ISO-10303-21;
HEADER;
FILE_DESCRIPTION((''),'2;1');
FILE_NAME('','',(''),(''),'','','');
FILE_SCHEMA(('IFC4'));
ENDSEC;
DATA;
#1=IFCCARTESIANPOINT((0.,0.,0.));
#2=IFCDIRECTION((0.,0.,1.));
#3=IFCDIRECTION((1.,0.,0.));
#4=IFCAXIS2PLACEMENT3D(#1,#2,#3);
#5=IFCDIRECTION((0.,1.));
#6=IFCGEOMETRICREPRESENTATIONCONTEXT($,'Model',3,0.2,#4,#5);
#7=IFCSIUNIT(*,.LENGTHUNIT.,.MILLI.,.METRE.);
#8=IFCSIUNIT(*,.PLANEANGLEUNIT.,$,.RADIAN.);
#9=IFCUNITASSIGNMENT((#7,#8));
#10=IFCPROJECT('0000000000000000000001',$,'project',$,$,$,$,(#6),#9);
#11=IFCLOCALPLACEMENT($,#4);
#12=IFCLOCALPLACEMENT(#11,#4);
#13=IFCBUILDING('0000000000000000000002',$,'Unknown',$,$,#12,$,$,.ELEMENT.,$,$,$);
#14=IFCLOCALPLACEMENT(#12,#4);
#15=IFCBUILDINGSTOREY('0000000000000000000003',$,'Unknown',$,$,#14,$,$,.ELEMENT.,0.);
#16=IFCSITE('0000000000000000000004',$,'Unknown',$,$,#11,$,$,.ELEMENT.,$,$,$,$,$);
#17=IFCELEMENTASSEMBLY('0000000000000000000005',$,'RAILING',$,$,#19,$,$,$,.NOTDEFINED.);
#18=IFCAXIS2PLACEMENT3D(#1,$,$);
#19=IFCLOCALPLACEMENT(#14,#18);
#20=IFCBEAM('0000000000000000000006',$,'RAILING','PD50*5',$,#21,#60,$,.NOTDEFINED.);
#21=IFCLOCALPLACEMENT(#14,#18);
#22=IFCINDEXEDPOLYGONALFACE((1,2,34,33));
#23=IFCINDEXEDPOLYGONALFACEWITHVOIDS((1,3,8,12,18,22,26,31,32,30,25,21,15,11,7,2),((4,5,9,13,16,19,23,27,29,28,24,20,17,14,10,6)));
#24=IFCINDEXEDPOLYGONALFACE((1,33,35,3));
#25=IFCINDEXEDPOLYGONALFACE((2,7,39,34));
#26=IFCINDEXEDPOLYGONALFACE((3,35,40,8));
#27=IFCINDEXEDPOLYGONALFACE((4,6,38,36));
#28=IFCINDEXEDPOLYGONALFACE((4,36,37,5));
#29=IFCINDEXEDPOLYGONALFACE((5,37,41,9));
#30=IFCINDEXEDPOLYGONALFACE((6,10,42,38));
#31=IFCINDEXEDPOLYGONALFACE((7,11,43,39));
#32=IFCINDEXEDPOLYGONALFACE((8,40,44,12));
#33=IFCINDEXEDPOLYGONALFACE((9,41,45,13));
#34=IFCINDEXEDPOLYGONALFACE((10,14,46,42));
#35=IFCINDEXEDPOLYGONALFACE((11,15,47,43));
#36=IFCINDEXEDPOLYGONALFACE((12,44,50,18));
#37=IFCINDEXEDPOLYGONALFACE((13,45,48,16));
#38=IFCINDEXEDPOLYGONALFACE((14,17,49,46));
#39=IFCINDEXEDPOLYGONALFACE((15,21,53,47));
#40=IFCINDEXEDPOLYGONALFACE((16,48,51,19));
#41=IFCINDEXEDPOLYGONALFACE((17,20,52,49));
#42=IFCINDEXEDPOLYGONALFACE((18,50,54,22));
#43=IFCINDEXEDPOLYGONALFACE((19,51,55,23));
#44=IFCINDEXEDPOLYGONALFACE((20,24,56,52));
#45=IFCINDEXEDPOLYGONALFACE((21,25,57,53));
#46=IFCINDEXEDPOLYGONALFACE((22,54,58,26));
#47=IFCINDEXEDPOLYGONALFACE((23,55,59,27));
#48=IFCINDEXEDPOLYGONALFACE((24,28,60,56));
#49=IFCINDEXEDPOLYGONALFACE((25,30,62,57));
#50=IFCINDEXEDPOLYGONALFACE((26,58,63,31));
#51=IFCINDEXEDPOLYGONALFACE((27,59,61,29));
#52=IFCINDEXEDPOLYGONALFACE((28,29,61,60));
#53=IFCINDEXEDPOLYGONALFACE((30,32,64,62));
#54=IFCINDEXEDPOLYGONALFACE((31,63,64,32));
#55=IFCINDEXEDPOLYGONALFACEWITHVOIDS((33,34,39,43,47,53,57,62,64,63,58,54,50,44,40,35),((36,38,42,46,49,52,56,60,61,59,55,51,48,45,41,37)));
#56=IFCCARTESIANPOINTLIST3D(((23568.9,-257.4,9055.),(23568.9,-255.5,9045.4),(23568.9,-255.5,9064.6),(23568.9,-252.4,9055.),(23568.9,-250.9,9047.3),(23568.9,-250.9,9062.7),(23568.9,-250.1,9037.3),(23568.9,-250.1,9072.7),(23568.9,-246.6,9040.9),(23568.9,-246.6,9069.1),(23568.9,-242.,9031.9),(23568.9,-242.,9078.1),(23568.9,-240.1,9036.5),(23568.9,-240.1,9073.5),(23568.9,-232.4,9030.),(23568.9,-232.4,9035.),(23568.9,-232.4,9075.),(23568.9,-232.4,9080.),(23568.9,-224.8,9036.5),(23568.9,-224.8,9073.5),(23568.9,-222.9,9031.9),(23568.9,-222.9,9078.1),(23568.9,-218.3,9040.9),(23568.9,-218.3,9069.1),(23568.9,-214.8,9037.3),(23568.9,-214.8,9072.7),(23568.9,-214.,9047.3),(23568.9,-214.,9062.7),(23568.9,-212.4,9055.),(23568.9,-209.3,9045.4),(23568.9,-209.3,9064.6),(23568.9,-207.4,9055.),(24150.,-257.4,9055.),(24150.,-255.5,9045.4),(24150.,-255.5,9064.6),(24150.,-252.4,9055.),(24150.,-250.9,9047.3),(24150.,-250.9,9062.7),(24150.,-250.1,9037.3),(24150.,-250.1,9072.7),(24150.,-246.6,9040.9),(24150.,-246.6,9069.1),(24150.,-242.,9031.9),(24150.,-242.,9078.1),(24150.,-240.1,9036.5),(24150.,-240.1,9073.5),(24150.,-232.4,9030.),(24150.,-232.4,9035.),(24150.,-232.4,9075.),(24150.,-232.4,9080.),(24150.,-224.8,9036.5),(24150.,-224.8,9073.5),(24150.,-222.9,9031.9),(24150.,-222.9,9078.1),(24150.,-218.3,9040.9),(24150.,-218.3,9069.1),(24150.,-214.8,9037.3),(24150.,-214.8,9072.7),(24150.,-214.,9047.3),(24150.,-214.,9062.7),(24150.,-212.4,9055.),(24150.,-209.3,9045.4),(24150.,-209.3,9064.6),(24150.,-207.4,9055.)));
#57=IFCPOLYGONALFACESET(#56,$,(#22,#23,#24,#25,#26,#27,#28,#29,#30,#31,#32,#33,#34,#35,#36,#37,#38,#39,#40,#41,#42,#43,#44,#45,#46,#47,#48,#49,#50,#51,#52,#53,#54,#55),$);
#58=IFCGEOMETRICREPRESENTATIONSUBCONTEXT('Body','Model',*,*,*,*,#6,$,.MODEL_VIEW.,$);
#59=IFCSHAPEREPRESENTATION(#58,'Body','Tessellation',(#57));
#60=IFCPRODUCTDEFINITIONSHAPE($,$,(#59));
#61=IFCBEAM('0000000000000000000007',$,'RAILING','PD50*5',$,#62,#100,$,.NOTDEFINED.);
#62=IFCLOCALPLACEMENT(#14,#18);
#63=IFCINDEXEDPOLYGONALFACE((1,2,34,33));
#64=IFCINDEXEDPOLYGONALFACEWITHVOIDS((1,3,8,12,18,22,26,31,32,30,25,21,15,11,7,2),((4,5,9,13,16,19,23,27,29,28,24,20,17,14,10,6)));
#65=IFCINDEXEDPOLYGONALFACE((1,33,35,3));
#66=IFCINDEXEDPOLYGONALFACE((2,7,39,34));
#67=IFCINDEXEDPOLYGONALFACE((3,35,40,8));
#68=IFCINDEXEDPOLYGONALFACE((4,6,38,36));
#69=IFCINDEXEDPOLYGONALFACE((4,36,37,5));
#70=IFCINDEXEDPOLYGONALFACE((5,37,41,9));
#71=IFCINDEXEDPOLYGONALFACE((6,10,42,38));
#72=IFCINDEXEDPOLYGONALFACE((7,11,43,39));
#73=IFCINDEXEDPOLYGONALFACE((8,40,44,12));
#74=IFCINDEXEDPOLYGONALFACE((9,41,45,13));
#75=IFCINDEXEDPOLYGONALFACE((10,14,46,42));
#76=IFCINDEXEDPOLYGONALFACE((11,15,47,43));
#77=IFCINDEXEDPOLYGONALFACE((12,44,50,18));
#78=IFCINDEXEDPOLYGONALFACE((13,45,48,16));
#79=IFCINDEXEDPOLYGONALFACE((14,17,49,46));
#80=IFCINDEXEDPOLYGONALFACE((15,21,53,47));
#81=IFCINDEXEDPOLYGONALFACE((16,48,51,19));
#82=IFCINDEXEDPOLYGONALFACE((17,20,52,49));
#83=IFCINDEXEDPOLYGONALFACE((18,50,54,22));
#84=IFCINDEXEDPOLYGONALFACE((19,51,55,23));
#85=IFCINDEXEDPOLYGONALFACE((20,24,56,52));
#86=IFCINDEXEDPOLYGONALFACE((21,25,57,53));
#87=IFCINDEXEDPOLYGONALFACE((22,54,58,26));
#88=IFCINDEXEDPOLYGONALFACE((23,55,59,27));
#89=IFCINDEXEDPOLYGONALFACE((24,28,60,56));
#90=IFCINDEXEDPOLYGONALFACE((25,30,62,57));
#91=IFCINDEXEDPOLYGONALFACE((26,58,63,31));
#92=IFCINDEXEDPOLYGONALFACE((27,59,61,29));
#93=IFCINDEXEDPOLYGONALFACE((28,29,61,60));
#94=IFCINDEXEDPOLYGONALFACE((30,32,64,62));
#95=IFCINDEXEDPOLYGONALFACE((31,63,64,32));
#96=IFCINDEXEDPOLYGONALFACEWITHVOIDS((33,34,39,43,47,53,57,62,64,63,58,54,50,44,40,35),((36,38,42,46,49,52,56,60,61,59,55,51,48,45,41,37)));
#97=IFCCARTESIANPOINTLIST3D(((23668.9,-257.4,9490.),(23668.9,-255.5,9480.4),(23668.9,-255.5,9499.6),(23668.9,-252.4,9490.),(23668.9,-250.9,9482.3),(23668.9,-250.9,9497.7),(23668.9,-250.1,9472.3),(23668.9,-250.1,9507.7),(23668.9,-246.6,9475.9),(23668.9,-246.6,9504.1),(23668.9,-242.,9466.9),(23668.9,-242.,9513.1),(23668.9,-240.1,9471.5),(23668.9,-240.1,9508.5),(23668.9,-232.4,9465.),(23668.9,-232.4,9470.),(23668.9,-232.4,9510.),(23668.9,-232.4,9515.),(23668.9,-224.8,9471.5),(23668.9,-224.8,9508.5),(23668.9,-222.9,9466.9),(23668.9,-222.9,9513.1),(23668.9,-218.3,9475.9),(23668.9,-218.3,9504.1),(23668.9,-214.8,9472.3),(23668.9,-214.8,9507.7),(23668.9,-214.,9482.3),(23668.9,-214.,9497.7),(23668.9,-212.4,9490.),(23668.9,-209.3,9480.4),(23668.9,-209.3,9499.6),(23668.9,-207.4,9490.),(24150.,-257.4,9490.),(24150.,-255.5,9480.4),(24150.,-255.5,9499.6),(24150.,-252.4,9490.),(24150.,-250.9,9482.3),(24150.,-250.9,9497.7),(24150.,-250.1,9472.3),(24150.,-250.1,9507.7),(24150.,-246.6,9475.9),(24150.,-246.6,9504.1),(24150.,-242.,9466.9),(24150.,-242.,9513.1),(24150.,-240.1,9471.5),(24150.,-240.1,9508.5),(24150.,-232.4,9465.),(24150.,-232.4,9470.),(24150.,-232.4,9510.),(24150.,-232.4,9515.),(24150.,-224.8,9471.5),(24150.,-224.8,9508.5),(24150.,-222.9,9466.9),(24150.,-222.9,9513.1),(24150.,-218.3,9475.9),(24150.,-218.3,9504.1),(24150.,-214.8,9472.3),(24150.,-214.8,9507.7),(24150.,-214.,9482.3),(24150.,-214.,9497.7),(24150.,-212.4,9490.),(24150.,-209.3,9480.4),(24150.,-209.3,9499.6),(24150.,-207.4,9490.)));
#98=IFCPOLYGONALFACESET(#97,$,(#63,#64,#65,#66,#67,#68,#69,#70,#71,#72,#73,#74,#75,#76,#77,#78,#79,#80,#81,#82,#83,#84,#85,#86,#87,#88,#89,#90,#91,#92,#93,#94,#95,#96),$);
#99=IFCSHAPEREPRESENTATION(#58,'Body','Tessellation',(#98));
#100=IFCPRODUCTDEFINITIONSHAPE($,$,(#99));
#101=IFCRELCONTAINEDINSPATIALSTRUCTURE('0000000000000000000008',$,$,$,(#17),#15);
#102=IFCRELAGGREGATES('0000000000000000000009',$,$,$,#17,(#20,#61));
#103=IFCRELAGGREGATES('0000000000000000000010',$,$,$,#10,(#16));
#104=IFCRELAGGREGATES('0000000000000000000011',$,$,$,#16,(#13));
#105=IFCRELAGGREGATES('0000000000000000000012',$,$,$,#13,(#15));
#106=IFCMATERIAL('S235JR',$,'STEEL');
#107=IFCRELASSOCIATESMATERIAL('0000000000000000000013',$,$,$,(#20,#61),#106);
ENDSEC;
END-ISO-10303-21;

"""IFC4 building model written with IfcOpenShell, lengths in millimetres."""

from ifc_helpers import new_model, si_unit, direction, frame, origin_with_axes, place, context, subcontext, project, spatial, line, indexed_curve, outline, extrude, material, element, aggregate, save


model = new_model("IFC4")

# Units and contexts
model_context = context("Model", 3, precision=0.2, world=origin_with_axes(), true_north=direction((0.0, 1.0)))
body_context = subcontext(model_context, "Body", "Model", "MODEL_VIEW")
ifc_project = project(units=[si_unit("LENGTHUNIT", "METRE", prefix="MILLI"), si_unit("PLANEANGLEUNIT", "RADIAN")], contexts=[model_context])

# Site, building, storey
site_placement = place(None, origin_with_axes())
site = spatial("IfcSite", under=ifc_project, at=site_placement, Name="Unknown", CompositionType="ELEMENT")
building_placement = place(site_placement, origin_with_axes())
building = spatial("IfcBuilding", under=site, at=building_placement, Name="Unknown", CompositionType="ELEMENT")
storey_placement = place(building_placement, origin_with_axes())
storey = spatial("IfcBuildingStorey", under=building, at=storey_placement, Name="Unknown", CompositionType="ELEMENT", Elevation=0.0)

# Shared definitions
ifc_material_1 = material(Name="S235JR", Category="STEEL")

# Element assembly, beams
assembly_1_placement = place(storey_placement, frame((24272.5, -1304.9, 9490.0), z_axis=(-1.0, 0.0, 0.0), x_axis=(0.0, 1.0, 0.0)))
assembly_1 = element("IfcElementAssembly", 1, at=assembly_1_placement, inside=storey, Name="RAILING", PredefinedType="NOTDEFINED")
beam_1_placement = place(assembly_1_placement, frame((1072.5, 435.0, 122.5), z_axis=(0.0, -1.0, 0.0), x_axis=(0.0, 0.0, 1.0)))
beam_1 = element("IfcBeam", 2, at=beam_1_placement, material=ifc_material_1, Name="RAILING", Description="PD50*5", PredefinedType="NOTDEFINED", context=body_context, shape_type="SolidModel", body=[
    extrude(outline(indexed_curve([(25.0, 0.0), (23.1, 9.6), (17.7, 17.7), (9.6, 23.1), (0.0, 25.0), (-9.6, 23.1), (-17.7, 17.7), (-23.1, 9.6), (-25.0, 0.0), (-23.1, -9.6), (-17.7, -17.7), (-9.6, -23.1), (0.0, -25.0), (9.6, -23.1), (17.7, -17.7), (23.1, -9.6)], segments=[line(1, 2, 3, 4, 5, 6, 7, 8, 9, 10, 11, 12, 13, 14, 15, 16, 1)]), holes=[indexed_curve([(20.0, 0.0), (18.5, -7.7), (14.1, -14.1), (7.7, -18.5), (0.0, -20.0), (-7.7, -18.5), (-14.1, -14.1), (-18.5, -7.7), (-20.0, 0.0), (-18.5, 7.7), (-14.1, 14.1), (-7.7, 18.5), (0.0, 20.0), (7.7, 18.5), (14.1, 14.1), (18.5, 7.7)], segments=[line(1, 2, 3, 4, 5, 6, 7, 8, 9, 10, 11, 12, 13, 14, 15, 16, 1)])]), frame((0.0, 0.0, 0.0), z_axis=(-1.0, 0.0, 0.0), x_axis=(0.0, 0.0, 1.0)), (0.0, 0.0, -1.0), 581.1),
])
beam_2_placement = place(assembly_1_placement, frame((1072.5, 0.0, 122.5), z_axis=(-1.0, 0.0, 0.0), x_axis=(0.0, 0.0, 1.0)))
beam_2 = element("IfcBeam", 3, at=beam_2_placement, material=ifc_material_1, Name="RAILING", Description="PD50*5", PredefinedType="NOTDEFINED", context=body_context, shape_type="SolidModel", body=[
    extrude(outline(indexed_curve([(25.0, 0.0), (23.1, 9.6), (17.7, 17.7), (9.6, 23.1), (0.0, 25.0), (-9.6, 23.1), (-17.7, 17.7), (-23.1, 9.6), (-25.0, 0.0), (-23.1, -9.6), (-17.7, -17.7), (-9.6, -23.1), (0.0, -25.0), (9.6, -23.1), (17.7, -17.7), (23.1, -9.6)], segments=[line(1, 2, 3, 4, 5, 6, 7, 8, 9, 10, 11, 12, 13, 14, 15, 16, 1)]), holes=[indexed_curve([(20.0, 0.0), (18.5, -7.7), (14.1, -14.1), (7.7, -18.5), (0.0, -20.0), (-7.7, -18.5), (-14.1, -14.1), (-18.5, -7.7), (-20.0, 0.0), (-18.5, 7.7), (-14.1, 14.1), (-7.7, 18.5), (0.0, 20.0), (7.7, 18.5), (14.1, 14.1), (18.5, 7.7)], segments=[line(1, 2, 3, 4, 5, 6, 7, 8, 9, 10, 11, 12, 13, 14, 15, 16, 1)])]), frame((0.0, 0.0, 0.0), z_axis=(-1.0, 0.0, 0.0), x_axis=(0.0, 0.0, 1.0)), (0.0, 0.0, -1.0), 481.1),
])

aggregate(assembly_1, [beam_1, beam_2])

save(model, "model.ifc")
